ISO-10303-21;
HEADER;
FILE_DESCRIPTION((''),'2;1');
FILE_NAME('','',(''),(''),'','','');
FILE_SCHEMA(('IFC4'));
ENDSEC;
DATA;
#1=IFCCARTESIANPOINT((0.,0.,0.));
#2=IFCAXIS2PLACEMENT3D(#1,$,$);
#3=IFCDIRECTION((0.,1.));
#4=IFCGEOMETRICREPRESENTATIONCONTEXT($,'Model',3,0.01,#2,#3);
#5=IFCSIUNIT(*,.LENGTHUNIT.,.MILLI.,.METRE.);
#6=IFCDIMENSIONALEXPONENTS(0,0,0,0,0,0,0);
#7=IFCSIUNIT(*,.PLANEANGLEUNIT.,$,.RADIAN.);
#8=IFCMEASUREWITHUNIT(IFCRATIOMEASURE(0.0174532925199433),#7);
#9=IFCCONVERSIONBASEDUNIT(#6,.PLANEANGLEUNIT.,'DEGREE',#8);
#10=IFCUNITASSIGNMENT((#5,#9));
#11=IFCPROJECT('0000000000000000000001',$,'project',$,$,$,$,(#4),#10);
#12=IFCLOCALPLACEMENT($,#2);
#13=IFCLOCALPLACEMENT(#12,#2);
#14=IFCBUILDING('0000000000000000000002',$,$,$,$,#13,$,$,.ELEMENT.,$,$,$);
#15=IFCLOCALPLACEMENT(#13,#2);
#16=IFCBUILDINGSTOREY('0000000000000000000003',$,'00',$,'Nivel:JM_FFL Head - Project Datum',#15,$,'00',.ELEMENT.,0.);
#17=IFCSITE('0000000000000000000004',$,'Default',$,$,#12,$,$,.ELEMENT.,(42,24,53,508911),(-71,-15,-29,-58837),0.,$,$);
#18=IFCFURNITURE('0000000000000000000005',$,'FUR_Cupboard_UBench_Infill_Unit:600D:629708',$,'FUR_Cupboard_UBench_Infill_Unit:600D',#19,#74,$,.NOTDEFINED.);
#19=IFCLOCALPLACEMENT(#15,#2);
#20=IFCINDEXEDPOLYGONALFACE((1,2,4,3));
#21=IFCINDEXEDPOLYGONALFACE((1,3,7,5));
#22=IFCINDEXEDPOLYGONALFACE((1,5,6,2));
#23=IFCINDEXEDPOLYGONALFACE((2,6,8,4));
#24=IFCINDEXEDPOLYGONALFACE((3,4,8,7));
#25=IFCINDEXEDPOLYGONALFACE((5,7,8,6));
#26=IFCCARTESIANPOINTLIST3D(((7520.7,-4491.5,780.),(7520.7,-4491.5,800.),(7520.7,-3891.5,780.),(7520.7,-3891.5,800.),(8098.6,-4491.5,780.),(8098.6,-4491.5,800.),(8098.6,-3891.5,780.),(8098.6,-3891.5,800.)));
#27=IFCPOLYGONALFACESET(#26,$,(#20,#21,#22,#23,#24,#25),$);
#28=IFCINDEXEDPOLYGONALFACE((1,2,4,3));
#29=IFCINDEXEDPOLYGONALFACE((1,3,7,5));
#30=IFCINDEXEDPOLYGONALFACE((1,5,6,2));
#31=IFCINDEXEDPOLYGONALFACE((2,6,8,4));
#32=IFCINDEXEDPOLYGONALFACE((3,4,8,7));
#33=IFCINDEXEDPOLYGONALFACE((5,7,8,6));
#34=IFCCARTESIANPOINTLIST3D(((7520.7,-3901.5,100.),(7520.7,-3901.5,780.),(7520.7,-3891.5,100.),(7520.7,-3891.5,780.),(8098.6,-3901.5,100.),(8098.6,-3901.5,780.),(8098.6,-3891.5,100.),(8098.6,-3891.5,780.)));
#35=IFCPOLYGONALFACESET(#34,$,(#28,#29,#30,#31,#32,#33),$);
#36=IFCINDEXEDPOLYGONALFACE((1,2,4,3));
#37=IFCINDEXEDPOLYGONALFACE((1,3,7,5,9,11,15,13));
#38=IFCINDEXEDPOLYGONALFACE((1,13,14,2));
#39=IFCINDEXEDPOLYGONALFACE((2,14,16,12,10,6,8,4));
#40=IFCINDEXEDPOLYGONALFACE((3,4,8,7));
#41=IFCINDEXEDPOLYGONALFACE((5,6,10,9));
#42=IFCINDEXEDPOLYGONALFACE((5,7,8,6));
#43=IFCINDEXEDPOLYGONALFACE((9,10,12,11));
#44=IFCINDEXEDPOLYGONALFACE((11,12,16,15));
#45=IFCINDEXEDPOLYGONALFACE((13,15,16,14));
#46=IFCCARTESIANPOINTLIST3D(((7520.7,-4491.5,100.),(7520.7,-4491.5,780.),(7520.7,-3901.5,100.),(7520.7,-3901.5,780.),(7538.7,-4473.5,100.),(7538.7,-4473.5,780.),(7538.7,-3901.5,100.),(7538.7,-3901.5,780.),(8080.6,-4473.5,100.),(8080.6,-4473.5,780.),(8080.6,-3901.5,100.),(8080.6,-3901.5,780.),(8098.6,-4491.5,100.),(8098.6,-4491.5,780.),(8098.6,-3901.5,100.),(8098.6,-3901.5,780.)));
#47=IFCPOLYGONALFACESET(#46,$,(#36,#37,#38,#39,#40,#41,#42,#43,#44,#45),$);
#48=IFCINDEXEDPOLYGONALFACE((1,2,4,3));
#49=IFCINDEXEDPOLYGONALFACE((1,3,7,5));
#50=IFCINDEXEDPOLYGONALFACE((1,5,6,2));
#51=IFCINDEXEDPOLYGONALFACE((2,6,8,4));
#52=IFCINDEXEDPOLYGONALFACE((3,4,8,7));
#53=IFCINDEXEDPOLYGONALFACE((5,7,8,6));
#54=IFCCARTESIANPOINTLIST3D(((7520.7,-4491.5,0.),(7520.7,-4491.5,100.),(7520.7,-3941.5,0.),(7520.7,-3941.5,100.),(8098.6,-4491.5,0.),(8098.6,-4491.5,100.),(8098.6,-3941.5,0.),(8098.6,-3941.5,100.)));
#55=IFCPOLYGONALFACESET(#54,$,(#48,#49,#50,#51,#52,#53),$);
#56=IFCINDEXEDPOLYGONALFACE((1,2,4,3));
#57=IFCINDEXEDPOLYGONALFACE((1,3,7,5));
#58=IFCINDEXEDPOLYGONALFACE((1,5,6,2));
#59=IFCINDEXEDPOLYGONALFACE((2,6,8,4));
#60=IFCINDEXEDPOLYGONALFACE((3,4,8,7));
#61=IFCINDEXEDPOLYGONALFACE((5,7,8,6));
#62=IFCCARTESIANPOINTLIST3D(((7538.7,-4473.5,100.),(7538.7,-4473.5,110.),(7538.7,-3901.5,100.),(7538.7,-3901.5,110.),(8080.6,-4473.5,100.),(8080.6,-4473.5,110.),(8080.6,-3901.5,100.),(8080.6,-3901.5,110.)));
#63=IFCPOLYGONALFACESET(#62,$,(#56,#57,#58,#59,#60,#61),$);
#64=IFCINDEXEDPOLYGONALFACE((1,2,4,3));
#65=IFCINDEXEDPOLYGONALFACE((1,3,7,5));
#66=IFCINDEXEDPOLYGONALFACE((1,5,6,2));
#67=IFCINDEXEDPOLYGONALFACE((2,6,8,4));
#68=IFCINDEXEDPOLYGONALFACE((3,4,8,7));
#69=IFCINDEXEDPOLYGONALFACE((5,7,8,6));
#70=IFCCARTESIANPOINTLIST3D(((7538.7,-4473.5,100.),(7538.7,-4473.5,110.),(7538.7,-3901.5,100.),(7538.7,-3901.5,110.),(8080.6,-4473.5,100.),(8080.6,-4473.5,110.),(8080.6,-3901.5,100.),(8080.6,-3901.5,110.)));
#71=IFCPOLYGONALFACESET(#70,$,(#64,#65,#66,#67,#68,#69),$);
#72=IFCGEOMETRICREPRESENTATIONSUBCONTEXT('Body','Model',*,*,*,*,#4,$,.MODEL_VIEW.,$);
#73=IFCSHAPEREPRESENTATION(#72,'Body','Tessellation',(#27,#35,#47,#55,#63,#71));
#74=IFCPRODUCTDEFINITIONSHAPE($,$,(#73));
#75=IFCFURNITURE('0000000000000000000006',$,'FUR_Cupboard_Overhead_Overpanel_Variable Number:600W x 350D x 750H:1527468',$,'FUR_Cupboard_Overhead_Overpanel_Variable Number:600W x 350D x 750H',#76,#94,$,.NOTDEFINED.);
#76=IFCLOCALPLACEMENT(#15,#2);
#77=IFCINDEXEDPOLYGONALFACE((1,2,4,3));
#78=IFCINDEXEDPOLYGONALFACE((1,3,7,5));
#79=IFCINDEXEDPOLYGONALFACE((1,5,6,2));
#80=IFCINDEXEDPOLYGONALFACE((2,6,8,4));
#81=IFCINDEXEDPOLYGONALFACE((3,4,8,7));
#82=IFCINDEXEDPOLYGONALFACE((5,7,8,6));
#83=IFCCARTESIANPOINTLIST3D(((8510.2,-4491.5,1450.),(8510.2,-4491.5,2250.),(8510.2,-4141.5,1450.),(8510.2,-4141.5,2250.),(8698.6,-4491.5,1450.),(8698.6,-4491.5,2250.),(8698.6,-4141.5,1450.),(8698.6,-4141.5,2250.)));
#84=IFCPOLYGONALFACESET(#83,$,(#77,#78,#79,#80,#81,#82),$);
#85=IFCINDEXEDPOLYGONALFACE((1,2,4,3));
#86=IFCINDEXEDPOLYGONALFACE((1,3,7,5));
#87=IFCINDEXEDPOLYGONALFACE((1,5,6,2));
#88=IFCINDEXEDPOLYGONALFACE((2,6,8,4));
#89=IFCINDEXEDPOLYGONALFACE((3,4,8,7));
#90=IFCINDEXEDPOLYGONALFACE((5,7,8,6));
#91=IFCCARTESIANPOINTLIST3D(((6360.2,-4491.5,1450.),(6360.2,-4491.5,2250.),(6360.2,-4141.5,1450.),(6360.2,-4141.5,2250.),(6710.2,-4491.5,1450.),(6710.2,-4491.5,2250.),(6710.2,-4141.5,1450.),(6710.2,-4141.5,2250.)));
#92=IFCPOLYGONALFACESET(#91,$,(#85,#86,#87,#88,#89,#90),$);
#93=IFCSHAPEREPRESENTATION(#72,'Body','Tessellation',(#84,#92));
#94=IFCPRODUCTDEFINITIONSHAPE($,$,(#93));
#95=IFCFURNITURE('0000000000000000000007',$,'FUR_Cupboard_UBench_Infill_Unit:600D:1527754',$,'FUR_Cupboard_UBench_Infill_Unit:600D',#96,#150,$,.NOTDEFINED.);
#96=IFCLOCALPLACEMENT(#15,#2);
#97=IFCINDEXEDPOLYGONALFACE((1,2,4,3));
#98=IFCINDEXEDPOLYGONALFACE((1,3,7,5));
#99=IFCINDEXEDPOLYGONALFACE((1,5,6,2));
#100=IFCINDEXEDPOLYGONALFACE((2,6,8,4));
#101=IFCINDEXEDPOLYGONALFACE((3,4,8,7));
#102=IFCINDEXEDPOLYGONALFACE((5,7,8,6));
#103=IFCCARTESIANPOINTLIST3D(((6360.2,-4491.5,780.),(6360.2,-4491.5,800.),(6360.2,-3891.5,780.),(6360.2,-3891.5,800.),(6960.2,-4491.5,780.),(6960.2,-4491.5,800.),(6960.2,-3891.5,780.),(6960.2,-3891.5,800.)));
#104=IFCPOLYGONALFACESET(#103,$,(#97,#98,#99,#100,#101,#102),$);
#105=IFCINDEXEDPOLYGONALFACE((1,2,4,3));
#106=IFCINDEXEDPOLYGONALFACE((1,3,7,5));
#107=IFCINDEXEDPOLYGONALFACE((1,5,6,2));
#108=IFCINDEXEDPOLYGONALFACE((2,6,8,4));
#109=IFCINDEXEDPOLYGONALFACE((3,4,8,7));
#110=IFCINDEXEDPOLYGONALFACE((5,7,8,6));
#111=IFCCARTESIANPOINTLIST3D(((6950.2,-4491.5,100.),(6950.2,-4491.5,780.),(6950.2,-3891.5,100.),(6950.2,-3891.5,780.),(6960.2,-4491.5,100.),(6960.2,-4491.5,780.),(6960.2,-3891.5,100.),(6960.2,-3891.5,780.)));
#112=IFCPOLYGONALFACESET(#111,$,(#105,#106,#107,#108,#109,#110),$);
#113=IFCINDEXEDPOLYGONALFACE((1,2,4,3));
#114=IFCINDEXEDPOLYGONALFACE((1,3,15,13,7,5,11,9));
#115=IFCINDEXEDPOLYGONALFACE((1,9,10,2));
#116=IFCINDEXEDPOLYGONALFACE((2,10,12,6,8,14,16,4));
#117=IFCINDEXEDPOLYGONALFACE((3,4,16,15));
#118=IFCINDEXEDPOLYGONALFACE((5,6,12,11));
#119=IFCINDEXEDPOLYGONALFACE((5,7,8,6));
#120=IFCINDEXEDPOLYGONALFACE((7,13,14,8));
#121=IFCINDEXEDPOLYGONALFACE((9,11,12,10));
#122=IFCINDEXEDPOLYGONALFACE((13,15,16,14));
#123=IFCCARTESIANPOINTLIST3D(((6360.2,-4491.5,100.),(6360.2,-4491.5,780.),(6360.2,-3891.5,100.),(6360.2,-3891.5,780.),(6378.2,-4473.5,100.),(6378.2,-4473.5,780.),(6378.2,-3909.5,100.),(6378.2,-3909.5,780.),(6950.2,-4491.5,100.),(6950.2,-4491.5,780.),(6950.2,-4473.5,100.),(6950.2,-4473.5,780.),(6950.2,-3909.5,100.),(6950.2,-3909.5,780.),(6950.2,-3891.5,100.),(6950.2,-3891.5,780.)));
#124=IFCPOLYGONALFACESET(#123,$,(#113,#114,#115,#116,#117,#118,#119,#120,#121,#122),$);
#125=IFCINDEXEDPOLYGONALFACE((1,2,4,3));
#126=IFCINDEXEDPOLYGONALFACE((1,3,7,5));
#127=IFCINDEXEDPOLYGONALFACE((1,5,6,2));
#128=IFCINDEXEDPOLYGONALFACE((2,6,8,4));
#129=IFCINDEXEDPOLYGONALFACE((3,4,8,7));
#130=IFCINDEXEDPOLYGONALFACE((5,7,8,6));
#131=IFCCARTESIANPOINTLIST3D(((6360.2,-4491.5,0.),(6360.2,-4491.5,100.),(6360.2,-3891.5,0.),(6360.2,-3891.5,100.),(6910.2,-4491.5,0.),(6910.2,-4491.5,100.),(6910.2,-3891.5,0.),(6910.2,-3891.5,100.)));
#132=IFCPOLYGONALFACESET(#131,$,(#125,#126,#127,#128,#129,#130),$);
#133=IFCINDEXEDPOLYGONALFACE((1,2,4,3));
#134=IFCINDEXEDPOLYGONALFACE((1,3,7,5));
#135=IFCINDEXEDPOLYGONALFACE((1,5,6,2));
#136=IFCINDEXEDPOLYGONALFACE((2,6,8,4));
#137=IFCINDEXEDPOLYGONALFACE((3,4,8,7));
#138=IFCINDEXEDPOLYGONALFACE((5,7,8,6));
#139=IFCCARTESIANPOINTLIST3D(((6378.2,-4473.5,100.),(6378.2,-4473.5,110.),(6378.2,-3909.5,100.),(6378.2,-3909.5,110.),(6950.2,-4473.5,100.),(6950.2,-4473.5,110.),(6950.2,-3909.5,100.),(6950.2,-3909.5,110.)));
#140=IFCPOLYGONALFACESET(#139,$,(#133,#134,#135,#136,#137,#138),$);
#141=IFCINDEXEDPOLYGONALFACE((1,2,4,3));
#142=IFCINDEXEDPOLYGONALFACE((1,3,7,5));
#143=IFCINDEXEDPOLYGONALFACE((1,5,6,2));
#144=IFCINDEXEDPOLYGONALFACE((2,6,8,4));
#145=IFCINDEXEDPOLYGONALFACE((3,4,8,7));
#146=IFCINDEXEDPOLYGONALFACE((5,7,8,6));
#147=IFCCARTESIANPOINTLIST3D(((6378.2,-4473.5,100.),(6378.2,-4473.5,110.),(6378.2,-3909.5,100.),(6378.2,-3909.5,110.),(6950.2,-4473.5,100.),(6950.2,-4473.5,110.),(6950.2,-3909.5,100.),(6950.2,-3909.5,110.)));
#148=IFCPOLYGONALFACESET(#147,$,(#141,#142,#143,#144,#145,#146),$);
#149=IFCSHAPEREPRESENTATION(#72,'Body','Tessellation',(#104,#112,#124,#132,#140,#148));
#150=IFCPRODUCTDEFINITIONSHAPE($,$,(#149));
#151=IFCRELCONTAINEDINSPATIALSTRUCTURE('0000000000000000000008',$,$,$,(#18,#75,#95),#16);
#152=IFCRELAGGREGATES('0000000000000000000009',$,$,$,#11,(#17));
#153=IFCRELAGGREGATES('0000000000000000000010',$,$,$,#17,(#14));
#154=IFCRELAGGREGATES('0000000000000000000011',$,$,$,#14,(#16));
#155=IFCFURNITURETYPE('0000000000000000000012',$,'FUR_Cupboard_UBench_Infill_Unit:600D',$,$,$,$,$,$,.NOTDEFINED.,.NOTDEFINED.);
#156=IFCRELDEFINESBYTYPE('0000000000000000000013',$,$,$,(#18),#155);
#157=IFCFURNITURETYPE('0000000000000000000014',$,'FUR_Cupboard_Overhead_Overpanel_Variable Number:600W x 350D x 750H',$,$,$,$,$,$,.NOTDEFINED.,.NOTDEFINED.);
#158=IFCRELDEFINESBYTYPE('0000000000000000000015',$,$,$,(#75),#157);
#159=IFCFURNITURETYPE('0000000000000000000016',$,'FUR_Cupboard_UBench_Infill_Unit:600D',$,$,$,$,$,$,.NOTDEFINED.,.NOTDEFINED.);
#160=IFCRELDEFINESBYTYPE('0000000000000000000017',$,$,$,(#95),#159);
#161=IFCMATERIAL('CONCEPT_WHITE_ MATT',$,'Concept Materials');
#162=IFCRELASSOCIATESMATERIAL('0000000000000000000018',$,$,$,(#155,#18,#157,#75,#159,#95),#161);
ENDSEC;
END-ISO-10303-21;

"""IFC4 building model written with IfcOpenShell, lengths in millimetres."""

from ifc_helpers import new_model, entity, si_unit, converted_unit, direction, frame, origin, place, context, subcontext, project, spatial, indexed_curve, outline, extrude, source, transform, mapped, material, type_object, type_shapes, element, save


model = new_model("IFC4")

# Units and contexts
model_context = context("Model", 3, precision=0.01, world=origin(), true_north=direction((0.0, 1.0)))
body_context = subcontext(model_context, "Body", "Model", "MODEL_VIEW")
ifc_project = project(units=[si_unit("LENGTHUNIT", "METRE", prefix="MILLI"), converted_unit("PLANEANGLEUNIT", "DEGREE", entity("IfcRatioMeasure", 0.0174532925199433), si_unit("PLANEANGLEUNIT", "RADIAN"), dimensions=[0, 0, 0, 0, 0, 0, 0])], contexts=[model_context])

# Site, building, storey
site_placement = place(None, origin())
site = spatial("IfcSite", under=ifc_project, at=site_placement, Name="Default", CompositionType="ELEMENT", RefLatitude=(42, 24, 53, 508911), RefLongitude=(-71, -15, -29, -58837), RefElevation=0.0)
building_placement = place(site_placement, origin())
building = spatial("IfcBuilding", under=site, at=building_placement, CompositionType="ELEMENT")
storey_placement = place(building_placement, origin())
storey = spatial("IfcBuildingStorey", under=building, at=storey_placement, Name="00", ObjectType="Nivel:JM_FFL Head - Project Datum", LongName="00", CompositionType="ELEMENT", Elevation=0.0)

# Furniture
ifc_material_1 = material(Name="CONCEPT_WHITE_ MATT", Category="Concept Materials")
furniture_type_1 = type_object("IfcFurnitureType", Name="FUR_Cupboard_UBench_Infill_Unit:600D", AssemblyPlace="NOTDEFINED", PredefinedType="NOTDEFINED", material=ifc_material_1)
shared_shape_1 = source(origin(), body_context, "Body", "SweptSolid", [
    extrude(outline(indexed_curve([(-300.0, -289.0), (300.0, -289.0), (300.0, 289.0), (-300.0, 289.0), (-300.0, -289.0)], self_intersect=False)), frame((44.7, 300.0, 780.0), z_axis=(0.0, 0.0, 1.0), x_axis=(0.0, 1.0, 0.0)), (0.0, 0.0, 1.0), 20.0),
    extrude(outline(indexed_curve([(-5.0, -289.0), (5.0, -289.0), (5.0, 289.0), (-5.0, 289.0), (-5.0, -289.0)], self_intersect=False)), frame((44.7, 595.0, 100.0), z_axis=(0.0, 0.0, 1.0), x_axis=(0.0, 1.0, 0.0)), (0.0, 0.0, 1.0), 680.0),
    extrude(outline(indexed_curve([(-299.5, -289.0), (290.5, -289.0), (290.5, -271.0), (-281.5, -271.0), (-281.5, 271.0), (290.5, 271.0), (290.5, 289.0), (-299.5, 289.0), (-299.5, -289.0)], self_intersect=False)), frame((44.7, 299.5, 100.0), z_axis=(0.0, 0.0, 1.0), x_axis=(0.0, 1.0, 0.0)), (0.0, 0.0, 1.0), 680.0),
    extrude(outline(indexed_curve([(-275.0, -289.0), (275.0, -289.0), (275.0, 289.0), (-275.0, 289.0), (-275.0, -289.0)], self_intersect=False)), frame((44.7, 275.0, 0.0), z_axis=(0.0, 0.0, 1.0), x_axis=(0.0, 1.0, 0.0)), (0.0, 0.0, 1.0), 100.0),
    extrude(outline(indexed_curve([(-286.0, -271.0), (286.0, -271.0), (286.0, 271.0), (-286.0, 271.0), (-286.0, -271.0)], self_intersect=False)), frame((44.7, 304.0, 100.0), z_axis=(0.0, 0.0, 1.0), x_axis=(0.0, 1.0, 0.0)), (0.0, 0.0, 1.0), 10.0),
    extrude(outline(indexed_curve([(-286.0, -271.0), (286.0, -271.0), (286.0, 271.0), (-286.0, 271.0), (-286.0, -271.0)], self_intersect=False)), frame((44.7, 304.0, 100.0), z_axis=(0.0, 0.0, 1.0), x_axis=(0.0, 1.0, 0.0)), (0.0, 0.0, 1.0), 10.0),
])
type_shapes(furniture_type_1, [shared_shape_1])
furniture_1_placement = place(storey_placement, frame((7765.0, -4491.5, 0.0)))
element("IfcFurniture", 1, at=furniture_1_placement, inside=storey, type_object=furniture_type_1, material=ifc_material_1, Name="FUR_Cupboard_UBench_Infill_Unit:600D:629708", ObjectType="FUR_Cupboard_UBench_Infill_Unit:600D", PredefinedType="NOTDEFINED", context=body_context, shape_type="MappedRepresentation", body=[
    mapped(shared_shape_1, transform((0.0, 0.0, 0.0), scale=1.0)),
])
furniture_type_2 = type_object("IfcFurnitureType", Name="FUR_Cupboard_Overhead_Overpanel_Variable Number:600W x 350D x 750H", AssemblyPlace="NOTDEFINED", PredefinedType="NOTDEFINED", material=ifc_material_1)
shared_shape_2 = source(origin(), body_context, "Body", "SweptSolid", [
    extrude(outline(indexed_curve([(-94.2, -175.0), (94.2, -175.0), (94.2, 175.0), (-94.2, 175.0), (-94.2, -175.0)], self_intersect=False)), frame((1894.2, 175.0, 1500.0)), (0.0, 0.0, 1.0), 800.0),
    extrude(outline(indexed_curve([(-175.0, -175.0), (175.0, -175.0), (175.0, 175.0), (-175.0, 175.0), (-175.0, -175.0)], self_intersect=False)), frame((-175.0, 175.0, 1500.0), z_axis=(0.0, 0.0, 1.0), x_axis=(0.0, 1.0, 0.0)), (0.0, 0.0, 1.0), 800.0),
])
type_shapes(furniture_type_2, [shared_shape_2])
furniture_2_placement = place(storey_placement, frame((6710.2, -4491.5, -50.0)))
element("IfcFurniture", 2, at=furniture_2_placement, inside=storey, type_object=furniture_type_2, material=ifc_material_1, Name="FUR_Cupboard_Overhead_Overpanel_Variable Number:600W x 350D x 750H:1527468", ObjectType="FUR_Cupboard_Overhead_Overpanel_Variable Number:600W x 350D x 750H", PredefinedType="NOTDEFINED", context=body_context, shape_type="MappedRepresentation", body=[
    mapped(shared_shape_2, transform((0.0, 0.0, 0.0), scale=1.0)),
])
furniture_type_3 = type_object("IfcFurnitureType", Name="FUR_Cupboard_UBench_Infill_Unit:600D", AssemblyPlace="NOTDEFINED", PredefinedType="NOTDEFINED", material=ifc_material_1)
shared_shape_3 = source(origin(), body_context, "Body", "SweptSolid", [
    extrude(outline(indexed_curve([(-300.0, -300.0), (300.0, -300.0), (300.0, 300.0), (-300.0, 300.0), (-300.0, -300.0)], self_intersect=False)), frame((44.7, 300.0, 780.0), z_axis=(0.0, 0.0, 1.0), x_axis=(0.0, 1.0, 0.0)), (0.0, 0.0, 1.0), 20.0),
    extrude(outline(indexed_curve([(-5.0, -300.0), (5.0, -300.0), (5.0, 300.0), (-5.0, 300.0), (-5.0, -300.0)], self_intersect=False)), frame((44.7, 595.0, 100.0), z_axis=(0.0, 0.0, 1.0), x_axis=(0.0, 1.0, 0.0)), (0.0, 0.0, 1.0), 680.0),
    extrude(outline(indexed_curve([(-299.5, -300.0), (290.5, -300.0), (290.5, -282.0), (-281.5, -282.0), (-281.5, 282.0), (290.5, 282.0), (290.5, 300.0), (-299.5, 300.0), (-299.5, -300.0)], self_intersect=False)), frame((44.7, 299.5, 100.0), z_axis=(0.0, 0.0, 1.0), x_axis=(0.0, 1.0, 0.0)), (0.0, 0.0, 1.0), 680.0),
    extrude(outline(indexed_curve([(-275.0, -300.0), (275.0, -300.0), (275.0, 300.0), (-275.0, 300.0), (-275.0, -300.0)], self_intersect=False)), frame((44.7, 275.0, 0.0), z_axis=(0.0, 0.0, 1.0), x_axis=(0.0, 1.0, 0.0)), (0.0, 0.0, 1.0), 100.0),
    extrude(outline(indexed_curve([(-286.0, -282.0), (286.0, -282.0), (286.0, 282.0), (-286.0, 282.0), (-286.0, -282.0)], self_intersect=False)), frame((44.7, 304.0, 100.0), z_axis=(0.0, 0.0, 1.0), x_axis=(0.0, 1.0, 0.0)), (0.0, 0.0, 1.0), 10.0),
    extrude(outline(indexed_curve([(-286.0, -282.0), (286.0, -282.0), (286.0, 282.0), (-286.0, 282.0), (-286.0, -282.0)], self_intersect=False)), frame((44.7, 304.0, 100.0), z_axis=(0.0, 0.0, 1.0), x_axis=(0.0, 1.0, 0.0)), (0.0, 0.0, 1.0), 10.0),
])
type_shapes(furniture_type_3, [shared_shape_3])
furniture_3_placement = place(storey_placement, frame((6360.2, -4146.8, 0.0), z_axis=(0.0, 0.0, 1.0), x_axis=(0.0, -1.0, 0.0)))
element("IfcFurniture", 3, at=furniture_3_placement, inside=storey, type_object=furniture_type_3, material=ifc_material_1, Name="FUR_Cupboard_UBench_Infill_Unit:600D:1527754", ObjectType="FUR_Cupboard_UBench_Infill_Unit:600D", PredefinedType="NOTDEFINED", context=body_context, shape_type="MappedRepresentation", body=[
    mapped(shared_shape_3, transform((0.0, 0.0, 0.0), scale=1.0)),
])

save(model, "model.ifc")
